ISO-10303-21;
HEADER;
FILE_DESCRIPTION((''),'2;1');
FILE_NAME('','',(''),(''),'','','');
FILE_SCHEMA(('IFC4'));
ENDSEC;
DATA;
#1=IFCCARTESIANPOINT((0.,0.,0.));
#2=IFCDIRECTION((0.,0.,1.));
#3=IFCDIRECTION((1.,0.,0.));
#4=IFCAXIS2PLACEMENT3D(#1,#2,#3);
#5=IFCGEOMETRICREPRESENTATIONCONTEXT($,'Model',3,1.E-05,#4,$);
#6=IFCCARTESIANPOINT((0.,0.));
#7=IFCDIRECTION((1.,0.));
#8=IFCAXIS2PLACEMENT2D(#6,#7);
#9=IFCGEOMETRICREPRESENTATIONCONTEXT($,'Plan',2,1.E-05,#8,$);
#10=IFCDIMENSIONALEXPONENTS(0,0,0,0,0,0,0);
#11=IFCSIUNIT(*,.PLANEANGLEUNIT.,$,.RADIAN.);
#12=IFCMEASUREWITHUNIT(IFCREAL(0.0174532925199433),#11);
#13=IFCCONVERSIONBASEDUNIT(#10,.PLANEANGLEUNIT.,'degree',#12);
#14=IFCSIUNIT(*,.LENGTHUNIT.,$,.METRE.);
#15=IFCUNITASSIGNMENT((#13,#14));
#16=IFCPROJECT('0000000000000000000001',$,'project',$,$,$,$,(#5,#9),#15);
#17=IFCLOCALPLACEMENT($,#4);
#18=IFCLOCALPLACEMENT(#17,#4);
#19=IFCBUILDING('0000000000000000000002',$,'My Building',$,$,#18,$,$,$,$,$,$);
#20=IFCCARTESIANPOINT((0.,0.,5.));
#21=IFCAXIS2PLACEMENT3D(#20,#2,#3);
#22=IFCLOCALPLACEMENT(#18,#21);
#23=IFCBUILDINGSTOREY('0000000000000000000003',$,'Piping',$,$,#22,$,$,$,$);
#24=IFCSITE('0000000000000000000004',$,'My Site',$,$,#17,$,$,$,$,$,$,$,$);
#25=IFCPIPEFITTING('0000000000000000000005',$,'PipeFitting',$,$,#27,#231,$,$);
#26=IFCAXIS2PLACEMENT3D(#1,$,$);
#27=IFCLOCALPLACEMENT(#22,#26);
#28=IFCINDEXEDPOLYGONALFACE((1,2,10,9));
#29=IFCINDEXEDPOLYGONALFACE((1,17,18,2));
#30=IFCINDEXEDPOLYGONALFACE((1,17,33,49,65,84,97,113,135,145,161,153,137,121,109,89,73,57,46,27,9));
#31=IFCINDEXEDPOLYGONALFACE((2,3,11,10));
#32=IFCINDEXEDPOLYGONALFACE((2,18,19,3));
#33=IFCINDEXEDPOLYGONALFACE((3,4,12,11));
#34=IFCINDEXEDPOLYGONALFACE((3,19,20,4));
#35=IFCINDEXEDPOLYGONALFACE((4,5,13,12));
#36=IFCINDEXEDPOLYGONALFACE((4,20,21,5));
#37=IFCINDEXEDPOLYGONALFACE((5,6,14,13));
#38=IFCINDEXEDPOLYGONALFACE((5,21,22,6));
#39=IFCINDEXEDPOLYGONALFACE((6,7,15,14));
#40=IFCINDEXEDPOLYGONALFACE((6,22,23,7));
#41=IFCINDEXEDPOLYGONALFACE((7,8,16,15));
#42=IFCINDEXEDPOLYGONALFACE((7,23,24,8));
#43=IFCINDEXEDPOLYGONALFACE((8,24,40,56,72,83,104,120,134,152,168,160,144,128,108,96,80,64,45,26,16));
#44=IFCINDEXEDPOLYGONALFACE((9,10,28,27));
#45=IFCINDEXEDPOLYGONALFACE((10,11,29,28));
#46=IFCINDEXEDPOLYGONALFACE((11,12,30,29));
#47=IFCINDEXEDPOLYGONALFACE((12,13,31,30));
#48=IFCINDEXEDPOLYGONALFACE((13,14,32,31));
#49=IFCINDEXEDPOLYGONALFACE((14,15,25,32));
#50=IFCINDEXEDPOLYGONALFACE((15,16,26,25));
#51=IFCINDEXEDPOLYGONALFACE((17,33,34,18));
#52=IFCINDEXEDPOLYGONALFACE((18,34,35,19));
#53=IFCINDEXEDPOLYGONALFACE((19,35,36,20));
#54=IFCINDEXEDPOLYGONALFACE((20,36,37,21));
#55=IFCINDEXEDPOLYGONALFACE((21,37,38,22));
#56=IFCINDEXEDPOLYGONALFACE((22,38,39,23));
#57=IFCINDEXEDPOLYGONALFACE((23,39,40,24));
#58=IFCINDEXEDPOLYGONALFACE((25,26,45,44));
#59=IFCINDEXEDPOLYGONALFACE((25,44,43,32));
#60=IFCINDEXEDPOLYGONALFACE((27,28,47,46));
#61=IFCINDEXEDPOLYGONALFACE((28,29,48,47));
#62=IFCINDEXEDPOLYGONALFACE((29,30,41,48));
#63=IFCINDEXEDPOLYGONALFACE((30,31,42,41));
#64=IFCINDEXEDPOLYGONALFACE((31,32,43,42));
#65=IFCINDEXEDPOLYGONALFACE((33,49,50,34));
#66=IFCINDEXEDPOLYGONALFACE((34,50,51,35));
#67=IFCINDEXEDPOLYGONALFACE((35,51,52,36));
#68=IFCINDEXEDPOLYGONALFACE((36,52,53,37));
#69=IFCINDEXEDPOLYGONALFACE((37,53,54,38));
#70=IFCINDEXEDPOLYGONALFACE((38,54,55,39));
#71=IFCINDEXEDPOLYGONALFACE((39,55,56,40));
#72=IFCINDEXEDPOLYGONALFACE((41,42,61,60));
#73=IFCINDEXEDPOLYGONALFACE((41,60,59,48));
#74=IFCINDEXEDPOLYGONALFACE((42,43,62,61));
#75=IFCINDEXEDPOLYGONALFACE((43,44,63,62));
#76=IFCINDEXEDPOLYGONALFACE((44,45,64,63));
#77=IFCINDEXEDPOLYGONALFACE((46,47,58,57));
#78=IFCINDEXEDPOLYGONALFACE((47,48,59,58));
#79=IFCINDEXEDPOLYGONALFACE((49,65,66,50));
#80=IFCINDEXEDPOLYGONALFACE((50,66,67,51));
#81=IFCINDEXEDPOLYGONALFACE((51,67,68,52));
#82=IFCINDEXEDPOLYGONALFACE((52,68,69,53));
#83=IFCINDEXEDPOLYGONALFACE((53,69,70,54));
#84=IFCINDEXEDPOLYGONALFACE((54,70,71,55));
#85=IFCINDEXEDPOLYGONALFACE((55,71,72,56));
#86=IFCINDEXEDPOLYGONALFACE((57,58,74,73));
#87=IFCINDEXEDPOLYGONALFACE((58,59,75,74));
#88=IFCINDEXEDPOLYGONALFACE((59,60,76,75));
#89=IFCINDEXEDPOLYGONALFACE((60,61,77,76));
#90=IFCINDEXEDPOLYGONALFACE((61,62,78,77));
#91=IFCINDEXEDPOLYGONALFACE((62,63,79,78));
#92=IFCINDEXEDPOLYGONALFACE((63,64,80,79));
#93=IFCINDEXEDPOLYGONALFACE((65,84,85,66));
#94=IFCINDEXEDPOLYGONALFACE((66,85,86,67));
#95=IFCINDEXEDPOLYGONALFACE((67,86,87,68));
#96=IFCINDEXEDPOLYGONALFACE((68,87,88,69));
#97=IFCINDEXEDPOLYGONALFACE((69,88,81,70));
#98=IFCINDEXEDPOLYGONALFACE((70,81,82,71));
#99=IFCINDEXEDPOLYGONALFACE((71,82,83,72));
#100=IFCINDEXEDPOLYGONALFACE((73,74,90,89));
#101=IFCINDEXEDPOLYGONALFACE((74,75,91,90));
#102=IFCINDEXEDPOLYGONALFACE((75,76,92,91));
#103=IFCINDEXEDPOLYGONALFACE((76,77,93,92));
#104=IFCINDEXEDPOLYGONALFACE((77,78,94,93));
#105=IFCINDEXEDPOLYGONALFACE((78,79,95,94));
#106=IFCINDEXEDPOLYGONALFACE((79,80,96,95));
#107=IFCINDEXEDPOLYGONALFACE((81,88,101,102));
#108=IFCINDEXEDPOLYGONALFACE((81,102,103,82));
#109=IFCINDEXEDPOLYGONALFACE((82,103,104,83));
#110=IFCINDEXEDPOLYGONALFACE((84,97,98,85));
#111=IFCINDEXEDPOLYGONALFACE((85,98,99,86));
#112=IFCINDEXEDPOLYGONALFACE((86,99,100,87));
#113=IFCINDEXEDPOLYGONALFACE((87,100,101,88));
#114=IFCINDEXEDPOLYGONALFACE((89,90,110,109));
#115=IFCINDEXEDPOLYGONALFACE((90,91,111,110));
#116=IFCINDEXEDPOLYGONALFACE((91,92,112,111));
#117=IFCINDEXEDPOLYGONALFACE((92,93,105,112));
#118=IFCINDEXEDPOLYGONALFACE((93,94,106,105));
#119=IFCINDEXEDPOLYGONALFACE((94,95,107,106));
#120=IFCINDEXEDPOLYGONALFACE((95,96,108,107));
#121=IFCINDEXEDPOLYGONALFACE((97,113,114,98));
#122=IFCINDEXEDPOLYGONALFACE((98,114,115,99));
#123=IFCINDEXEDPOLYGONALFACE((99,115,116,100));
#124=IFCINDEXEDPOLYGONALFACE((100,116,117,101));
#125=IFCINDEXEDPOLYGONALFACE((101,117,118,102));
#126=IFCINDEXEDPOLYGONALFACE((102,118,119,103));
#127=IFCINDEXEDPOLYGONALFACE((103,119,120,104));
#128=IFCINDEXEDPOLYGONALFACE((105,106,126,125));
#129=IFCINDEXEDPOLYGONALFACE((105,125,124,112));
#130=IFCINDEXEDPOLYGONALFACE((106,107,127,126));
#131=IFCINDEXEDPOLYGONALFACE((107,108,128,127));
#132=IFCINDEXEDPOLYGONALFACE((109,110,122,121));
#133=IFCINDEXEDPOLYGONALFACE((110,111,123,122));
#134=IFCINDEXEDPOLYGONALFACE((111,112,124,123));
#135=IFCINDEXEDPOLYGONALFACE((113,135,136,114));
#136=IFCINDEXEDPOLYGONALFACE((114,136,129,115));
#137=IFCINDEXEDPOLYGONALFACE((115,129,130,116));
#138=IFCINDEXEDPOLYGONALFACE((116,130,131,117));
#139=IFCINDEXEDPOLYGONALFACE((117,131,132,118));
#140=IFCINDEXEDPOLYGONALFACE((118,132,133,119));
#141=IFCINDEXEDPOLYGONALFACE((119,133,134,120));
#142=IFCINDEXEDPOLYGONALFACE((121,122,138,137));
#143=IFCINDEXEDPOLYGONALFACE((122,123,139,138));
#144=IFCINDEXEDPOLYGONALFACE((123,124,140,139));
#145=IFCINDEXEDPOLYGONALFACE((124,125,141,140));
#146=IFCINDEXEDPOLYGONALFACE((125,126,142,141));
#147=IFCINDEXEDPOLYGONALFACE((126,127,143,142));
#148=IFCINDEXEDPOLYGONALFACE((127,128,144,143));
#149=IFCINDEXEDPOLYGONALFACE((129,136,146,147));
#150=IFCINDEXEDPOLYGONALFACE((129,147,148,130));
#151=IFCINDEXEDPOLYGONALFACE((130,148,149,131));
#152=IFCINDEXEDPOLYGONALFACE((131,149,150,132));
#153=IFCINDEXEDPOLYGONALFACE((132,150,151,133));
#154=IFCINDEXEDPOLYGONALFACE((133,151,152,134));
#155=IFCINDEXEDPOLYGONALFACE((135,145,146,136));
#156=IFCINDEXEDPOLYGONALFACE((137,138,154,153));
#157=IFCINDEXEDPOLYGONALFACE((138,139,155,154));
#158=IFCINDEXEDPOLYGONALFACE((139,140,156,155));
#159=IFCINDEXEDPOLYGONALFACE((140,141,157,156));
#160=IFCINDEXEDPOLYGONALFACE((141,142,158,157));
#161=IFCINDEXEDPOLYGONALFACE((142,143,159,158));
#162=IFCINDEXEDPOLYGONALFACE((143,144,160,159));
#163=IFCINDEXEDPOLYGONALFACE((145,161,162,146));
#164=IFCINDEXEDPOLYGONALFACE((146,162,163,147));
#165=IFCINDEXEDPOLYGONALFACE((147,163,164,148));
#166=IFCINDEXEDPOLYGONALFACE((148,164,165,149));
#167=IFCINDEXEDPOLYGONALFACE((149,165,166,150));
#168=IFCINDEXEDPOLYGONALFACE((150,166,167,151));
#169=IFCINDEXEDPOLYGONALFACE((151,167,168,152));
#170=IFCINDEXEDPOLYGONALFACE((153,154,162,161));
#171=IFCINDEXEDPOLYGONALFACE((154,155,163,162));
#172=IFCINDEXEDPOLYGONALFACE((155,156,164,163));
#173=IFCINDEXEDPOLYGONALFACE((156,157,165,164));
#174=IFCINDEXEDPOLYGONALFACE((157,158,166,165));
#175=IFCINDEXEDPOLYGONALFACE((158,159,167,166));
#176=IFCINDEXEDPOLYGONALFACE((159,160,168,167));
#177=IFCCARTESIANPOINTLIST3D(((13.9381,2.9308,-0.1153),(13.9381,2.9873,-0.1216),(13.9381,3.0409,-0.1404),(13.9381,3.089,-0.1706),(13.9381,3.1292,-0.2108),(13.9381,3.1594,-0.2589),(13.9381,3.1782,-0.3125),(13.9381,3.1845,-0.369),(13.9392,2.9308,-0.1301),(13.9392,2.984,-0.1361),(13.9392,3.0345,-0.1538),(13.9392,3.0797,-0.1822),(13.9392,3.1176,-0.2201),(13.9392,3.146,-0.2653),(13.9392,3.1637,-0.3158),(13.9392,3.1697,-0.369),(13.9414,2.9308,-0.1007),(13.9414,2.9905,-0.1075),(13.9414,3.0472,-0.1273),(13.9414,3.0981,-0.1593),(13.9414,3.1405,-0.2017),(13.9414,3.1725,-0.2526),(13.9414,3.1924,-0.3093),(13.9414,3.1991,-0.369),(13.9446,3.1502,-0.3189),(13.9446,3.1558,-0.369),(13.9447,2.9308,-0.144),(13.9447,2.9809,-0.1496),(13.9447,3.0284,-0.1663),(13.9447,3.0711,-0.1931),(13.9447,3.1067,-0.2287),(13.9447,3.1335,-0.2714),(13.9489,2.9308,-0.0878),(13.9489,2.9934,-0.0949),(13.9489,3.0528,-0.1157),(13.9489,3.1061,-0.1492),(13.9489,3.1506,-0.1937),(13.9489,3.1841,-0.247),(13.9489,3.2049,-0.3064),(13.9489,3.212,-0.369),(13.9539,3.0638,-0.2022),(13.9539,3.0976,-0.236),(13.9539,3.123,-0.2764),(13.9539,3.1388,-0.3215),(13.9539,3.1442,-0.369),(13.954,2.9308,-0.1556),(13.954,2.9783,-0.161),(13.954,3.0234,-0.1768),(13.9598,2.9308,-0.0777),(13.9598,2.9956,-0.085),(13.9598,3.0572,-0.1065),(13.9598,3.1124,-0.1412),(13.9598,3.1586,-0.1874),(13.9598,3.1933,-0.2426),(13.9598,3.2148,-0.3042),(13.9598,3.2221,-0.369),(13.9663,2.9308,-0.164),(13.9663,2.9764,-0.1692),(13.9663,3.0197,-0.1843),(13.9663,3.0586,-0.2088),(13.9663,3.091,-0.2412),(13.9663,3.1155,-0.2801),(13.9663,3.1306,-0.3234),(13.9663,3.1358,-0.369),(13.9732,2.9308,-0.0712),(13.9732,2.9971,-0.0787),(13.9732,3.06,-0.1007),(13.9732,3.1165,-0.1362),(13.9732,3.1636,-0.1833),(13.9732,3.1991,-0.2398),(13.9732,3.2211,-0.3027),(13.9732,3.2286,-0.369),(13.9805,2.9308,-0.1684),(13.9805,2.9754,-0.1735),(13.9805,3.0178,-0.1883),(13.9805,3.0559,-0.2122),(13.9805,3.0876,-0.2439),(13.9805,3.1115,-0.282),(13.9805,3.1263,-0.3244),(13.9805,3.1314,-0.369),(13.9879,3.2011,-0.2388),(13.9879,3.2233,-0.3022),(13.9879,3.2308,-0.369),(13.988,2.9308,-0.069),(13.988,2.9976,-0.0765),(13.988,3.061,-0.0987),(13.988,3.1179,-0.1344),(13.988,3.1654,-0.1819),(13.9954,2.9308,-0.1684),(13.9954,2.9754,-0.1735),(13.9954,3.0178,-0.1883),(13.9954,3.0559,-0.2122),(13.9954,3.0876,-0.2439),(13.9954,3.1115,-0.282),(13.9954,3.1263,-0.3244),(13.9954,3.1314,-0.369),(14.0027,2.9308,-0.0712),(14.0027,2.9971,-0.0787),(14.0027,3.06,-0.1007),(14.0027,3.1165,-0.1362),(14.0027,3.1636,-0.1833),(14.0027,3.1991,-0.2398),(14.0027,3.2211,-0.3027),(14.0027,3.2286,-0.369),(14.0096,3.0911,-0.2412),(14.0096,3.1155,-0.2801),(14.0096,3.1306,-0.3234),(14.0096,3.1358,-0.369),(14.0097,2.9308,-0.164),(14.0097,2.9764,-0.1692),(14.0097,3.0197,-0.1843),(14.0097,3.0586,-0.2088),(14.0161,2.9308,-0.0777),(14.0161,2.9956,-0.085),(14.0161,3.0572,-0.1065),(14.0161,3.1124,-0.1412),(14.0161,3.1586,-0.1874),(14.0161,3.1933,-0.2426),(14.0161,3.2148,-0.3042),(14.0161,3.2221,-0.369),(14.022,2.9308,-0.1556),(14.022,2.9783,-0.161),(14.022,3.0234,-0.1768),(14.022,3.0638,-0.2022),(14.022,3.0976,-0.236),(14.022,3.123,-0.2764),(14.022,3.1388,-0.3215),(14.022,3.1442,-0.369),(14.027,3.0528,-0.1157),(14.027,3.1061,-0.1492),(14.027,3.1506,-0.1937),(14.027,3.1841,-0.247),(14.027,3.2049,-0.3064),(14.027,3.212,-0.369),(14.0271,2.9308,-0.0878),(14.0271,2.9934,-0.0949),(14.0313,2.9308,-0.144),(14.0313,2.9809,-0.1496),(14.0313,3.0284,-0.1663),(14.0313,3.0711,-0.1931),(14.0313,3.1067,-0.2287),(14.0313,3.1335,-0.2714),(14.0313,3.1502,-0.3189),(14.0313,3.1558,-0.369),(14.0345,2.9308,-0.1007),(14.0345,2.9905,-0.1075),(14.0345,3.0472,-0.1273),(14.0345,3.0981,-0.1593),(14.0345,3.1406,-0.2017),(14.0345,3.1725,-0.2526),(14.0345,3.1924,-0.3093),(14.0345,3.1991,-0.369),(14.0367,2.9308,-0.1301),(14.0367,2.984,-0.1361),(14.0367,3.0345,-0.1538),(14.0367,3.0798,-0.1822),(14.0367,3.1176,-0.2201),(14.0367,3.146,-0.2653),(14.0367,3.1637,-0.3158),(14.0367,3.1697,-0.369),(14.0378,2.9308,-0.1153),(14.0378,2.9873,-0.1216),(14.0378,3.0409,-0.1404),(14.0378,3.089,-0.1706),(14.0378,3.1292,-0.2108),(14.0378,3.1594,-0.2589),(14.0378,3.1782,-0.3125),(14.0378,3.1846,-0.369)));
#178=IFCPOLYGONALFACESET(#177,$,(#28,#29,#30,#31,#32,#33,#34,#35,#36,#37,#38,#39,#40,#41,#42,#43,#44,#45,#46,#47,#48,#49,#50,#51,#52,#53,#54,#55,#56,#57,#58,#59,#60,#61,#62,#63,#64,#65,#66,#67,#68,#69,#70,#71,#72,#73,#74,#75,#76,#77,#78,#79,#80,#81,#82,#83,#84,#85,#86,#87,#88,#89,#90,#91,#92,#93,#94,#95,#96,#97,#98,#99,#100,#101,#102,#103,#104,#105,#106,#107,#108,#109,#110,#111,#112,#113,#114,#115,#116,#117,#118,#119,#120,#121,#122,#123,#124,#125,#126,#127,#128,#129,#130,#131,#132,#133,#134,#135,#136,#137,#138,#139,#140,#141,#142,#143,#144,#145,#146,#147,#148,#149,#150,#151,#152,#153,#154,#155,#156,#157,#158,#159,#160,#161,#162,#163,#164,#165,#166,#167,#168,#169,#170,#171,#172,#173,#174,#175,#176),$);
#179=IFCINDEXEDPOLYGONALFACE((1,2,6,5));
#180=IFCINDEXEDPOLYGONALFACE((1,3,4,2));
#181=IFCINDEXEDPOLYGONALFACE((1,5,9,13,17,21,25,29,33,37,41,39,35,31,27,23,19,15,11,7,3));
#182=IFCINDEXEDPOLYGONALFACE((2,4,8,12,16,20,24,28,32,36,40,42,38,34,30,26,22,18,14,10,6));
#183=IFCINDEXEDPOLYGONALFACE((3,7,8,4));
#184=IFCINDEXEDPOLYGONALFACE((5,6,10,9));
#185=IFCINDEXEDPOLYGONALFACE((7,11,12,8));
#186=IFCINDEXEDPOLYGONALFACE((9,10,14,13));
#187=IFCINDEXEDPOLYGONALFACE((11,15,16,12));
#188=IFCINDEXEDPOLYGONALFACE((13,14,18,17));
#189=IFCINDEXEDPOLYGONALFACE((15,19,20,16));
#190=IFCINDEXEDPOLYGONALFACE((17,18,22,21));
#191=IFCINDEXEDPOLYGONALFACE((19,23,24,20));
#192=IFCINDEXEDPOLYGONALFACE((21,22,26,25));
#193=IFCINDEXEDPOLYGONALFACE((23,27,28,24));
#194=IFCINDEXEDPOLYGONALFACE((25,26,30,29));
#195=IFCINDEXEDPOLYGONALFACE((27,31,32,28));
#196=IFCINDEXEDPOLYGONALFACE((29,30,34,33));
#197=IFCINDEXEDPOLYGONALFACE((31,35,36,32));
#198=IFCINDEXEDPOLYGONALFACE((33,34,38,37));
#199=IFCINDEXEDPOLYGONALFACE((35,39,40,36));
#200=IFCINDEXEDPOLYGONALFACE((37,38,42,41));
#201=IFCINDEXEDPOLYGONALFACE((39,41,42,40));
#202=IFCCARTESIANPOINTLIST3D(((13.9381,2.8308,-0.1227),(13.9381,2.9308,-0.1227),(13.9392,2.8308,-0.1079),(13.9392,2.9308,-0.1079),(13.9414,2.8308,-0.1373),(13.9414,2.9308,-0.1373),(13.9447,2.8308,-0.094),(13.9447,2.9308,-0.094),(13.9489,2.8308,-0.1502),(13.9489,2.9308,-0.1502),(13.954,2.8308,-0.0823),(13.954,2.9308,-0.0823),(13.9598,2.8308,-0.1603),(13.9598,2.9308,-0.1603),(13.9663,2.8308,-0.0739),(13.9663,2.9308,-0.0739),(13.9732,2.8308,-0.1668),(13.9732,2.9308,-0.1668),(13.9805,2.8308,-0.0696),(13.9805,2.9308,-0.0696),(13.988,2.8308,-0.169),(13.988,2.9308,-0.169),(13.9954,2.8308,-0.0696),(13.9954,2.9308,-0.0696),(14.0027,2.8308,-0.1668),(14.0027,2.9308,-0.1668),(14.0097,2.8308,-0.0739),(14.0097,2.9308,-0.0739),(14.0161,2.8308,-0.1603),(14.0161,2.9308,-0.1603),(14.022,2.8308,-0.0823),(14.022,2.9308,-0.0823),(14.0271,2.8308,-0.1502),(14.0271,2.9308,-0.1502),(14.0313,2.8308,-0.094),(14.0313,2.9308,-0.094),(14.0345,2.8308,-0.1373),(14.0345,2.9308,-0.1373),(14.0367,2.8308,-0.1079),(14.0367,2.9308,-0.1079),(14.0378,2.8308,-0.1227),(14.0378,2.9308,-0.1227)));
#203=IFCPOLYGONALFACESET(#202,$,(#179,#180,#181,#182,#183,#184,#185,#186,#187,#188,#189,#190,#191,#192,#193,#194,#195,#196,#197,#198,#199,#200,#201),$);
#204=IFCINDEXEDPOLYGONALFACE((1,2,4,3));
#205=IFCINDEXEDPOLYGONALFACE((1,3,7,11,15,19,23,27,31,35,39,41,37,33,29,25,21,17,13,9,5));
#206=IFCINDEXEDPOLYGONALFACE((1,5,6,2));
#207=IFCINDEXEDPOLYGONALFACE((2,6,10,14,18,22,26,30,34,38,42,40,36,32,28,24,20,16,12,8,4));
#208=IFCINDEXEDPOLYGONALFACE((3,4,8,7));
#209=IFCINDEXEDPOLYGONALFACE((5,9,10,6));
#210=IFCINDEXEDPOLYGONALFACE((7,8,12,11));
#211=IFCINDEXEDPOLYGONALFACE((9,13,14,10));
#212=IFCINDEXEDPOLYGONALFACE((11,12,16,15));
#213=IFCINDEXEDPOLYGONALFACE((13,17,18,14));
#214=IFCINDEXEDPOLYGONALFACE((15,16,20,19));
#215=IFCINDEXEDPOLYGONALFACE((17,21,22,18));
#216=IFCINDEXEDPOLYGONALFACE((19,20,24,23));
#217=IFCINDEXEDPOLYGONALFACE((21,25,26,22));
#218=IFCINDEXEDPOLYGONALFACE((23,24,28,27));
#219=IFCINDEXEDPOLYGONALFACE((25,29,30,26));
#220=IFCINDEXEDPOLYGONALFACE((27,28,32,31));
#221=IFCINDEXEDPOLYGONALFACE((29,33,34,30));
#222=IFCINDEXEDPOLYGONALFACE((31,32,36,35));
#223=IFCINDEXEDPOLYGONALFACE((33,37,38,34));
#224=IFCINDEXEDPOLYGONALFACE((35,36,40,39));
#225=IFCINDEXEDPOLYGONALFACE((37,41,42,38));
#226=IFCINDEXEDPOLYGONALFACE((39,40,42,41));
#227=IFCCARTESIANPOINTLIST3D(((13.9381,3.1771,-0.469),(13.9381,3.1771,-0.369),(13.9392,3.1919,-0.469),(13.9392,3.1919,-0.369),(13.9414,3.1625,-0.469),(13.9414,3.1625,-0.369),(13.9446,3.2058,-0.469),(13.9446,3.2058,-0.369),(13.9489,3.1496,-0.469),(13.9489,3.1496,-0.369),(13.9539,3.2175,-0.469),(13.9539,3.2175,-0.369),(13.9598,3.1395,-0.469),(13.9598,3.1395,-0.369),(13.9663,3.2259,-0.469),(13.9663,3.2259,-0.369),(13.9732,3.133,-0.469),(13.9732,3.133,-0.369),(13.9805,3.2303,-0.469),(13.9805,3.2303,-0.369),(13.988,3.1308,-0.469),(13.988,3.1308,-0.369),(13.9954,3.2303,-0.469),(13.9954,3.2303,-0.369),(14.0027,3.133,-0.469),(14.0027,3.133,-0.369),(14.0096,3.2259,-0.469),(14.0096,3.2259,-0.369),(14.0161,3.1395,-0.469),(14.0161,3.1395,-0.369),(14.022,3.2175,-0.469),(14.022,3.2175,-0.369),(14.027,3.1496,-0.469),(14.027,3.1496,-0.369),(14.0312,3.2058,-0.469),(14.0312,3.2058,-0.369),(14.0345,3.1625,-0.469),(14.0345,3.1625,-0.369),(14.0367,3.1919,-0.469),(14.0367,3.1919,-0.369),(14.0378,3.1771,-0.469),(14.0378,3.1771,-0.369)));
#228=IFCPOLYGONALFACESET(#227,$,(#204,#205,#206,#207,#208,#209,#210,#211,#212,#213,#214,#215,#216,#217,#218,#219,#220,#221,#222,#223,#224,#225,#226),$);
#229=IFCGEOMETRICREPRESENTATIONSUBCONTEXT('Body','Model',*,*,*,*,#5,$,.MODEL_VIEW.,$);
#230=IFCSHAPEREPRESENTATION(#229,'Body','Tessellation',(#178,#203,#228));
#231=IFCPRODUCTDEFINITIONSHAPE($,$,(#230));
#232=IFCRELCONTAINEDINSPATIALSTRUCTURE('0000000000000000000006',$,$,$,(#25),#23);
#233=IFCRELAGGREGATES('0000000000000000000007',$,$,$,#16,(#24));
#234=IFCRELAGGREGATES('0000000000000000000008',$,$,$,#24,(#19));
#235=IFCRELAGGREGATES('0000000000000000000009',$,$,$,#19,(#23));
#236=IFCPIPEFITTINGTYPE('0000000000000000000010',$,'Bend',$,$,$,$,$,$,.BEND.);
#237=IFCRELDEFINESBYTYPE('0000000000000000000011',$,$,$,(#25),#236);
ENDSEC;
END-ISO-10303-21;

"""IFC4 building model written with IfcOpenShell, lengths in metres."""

from ifc_helpers import new_model, entity, si_unit, converted_unit, frame, origin_with_axes, origin_2d_with_axis, place, context, subcontext, project, spatial, circle, extrude, source, transform, mapped, type_object, type_shapes, element, save


model = new_model("IFC4")

# Units and contexts
model_context = context("Model", 3, precision=1e-05, world=origin_with_axes())
plan_context = context("Plan", 2, precision=1e-05, world=origin_2d_with_axis())
body_context = subcontext(model_context, "Body", "Model", "MODEL_VIEW")
ifc_project = project(units=[converted_unit("PLANEANGLEUNIT", "degree", entity("IfcReal", 0.0174532925199433), si_unit("PLANEANGLEUNIT", "RADIAN"), dimensions=[0, 0, 0, 0, 0, 0, 0]), si_unit("LENGTHUNIT", "METRE")], contexts=[model_context, plan_context])

# Site, building, storey
site_placement = place(None, origin_with_axes())
site = spatial("IfcSite", under=ifc_project, at=site_placement, Name="My Site")
building_placement = place(site_placement, origin_with_axes())
building = spatial("IfcBuilding", under=site, at=building_placement, Name="My Building")
storey_placement = place(building_placement, frame((0.0, 0.0, 5.0), z_axis=(0.0, 0.0, 1.0), x_axis=(1.0, 0.0, 0.0)))
storey = spatial("IfcBuildingStorey", under=building, at=storey_placement, Name="Piping")

# Pipe fitting
pipe_fitting_type_1 = type_object("IfcPipeFittingType", Name="Bend", PredefinedType="BEND")
shared_shape = source(origin_with_axes(), body_context, "Body", "SolidModel", [
    entity("IfcSweptDiskSolid", entity("IfcIndexedPolyCurve", entity("IfcCartesianPointList3D", [[0.0, 0.0, -0.1], [0.0732, 0.0, -0.2768], [0.25, 0.0, -0.35]]), [entity("IfcArcIndex", [1, 2, 3])]), 0.05),
    extrude(circle(Radius=0.05), origin_with_axes(), (0.0, 0.0, -1.0), 0.1),
    extrude(circle(Radius=0.05), frame((0.25, 0.0, -0.35), z_axis=(1.0, 0.0, 0.0), x_axis=(0.0, 0.0, 1.0)), (0.0, 0.0, 1.0), 0.1),
])
type_shapes(pipe_fitting_type_1, [shared_shape])
for number, where, z_axis, x_axis, name in (
    (1, (13.988, 2.8308, -0.119), (0.00006, -1.0, 0.0), (0.0, 0.0, -1.0), "PipeFitting"),
):
    element("IfcPipeFitting", number, at=place(storey_placement, frame(where, z_axis=z_axis, x_axis=x_axis)), inside=storey, type_object=pipe_fitting_type_1, Name=name, context=body_context, shape_type="MappedRepresentation", body=[
        mapped(shared_shape, transform((0.0, 0.0, 0.0), x_axis=(1.0, 0.0, 0.0), y_axis=(0.0, 1.0, 0.0), z_axis=(0.0, 0.0, 1.0), scale=1.0)),
    ])

save(model, "model.ifc")
